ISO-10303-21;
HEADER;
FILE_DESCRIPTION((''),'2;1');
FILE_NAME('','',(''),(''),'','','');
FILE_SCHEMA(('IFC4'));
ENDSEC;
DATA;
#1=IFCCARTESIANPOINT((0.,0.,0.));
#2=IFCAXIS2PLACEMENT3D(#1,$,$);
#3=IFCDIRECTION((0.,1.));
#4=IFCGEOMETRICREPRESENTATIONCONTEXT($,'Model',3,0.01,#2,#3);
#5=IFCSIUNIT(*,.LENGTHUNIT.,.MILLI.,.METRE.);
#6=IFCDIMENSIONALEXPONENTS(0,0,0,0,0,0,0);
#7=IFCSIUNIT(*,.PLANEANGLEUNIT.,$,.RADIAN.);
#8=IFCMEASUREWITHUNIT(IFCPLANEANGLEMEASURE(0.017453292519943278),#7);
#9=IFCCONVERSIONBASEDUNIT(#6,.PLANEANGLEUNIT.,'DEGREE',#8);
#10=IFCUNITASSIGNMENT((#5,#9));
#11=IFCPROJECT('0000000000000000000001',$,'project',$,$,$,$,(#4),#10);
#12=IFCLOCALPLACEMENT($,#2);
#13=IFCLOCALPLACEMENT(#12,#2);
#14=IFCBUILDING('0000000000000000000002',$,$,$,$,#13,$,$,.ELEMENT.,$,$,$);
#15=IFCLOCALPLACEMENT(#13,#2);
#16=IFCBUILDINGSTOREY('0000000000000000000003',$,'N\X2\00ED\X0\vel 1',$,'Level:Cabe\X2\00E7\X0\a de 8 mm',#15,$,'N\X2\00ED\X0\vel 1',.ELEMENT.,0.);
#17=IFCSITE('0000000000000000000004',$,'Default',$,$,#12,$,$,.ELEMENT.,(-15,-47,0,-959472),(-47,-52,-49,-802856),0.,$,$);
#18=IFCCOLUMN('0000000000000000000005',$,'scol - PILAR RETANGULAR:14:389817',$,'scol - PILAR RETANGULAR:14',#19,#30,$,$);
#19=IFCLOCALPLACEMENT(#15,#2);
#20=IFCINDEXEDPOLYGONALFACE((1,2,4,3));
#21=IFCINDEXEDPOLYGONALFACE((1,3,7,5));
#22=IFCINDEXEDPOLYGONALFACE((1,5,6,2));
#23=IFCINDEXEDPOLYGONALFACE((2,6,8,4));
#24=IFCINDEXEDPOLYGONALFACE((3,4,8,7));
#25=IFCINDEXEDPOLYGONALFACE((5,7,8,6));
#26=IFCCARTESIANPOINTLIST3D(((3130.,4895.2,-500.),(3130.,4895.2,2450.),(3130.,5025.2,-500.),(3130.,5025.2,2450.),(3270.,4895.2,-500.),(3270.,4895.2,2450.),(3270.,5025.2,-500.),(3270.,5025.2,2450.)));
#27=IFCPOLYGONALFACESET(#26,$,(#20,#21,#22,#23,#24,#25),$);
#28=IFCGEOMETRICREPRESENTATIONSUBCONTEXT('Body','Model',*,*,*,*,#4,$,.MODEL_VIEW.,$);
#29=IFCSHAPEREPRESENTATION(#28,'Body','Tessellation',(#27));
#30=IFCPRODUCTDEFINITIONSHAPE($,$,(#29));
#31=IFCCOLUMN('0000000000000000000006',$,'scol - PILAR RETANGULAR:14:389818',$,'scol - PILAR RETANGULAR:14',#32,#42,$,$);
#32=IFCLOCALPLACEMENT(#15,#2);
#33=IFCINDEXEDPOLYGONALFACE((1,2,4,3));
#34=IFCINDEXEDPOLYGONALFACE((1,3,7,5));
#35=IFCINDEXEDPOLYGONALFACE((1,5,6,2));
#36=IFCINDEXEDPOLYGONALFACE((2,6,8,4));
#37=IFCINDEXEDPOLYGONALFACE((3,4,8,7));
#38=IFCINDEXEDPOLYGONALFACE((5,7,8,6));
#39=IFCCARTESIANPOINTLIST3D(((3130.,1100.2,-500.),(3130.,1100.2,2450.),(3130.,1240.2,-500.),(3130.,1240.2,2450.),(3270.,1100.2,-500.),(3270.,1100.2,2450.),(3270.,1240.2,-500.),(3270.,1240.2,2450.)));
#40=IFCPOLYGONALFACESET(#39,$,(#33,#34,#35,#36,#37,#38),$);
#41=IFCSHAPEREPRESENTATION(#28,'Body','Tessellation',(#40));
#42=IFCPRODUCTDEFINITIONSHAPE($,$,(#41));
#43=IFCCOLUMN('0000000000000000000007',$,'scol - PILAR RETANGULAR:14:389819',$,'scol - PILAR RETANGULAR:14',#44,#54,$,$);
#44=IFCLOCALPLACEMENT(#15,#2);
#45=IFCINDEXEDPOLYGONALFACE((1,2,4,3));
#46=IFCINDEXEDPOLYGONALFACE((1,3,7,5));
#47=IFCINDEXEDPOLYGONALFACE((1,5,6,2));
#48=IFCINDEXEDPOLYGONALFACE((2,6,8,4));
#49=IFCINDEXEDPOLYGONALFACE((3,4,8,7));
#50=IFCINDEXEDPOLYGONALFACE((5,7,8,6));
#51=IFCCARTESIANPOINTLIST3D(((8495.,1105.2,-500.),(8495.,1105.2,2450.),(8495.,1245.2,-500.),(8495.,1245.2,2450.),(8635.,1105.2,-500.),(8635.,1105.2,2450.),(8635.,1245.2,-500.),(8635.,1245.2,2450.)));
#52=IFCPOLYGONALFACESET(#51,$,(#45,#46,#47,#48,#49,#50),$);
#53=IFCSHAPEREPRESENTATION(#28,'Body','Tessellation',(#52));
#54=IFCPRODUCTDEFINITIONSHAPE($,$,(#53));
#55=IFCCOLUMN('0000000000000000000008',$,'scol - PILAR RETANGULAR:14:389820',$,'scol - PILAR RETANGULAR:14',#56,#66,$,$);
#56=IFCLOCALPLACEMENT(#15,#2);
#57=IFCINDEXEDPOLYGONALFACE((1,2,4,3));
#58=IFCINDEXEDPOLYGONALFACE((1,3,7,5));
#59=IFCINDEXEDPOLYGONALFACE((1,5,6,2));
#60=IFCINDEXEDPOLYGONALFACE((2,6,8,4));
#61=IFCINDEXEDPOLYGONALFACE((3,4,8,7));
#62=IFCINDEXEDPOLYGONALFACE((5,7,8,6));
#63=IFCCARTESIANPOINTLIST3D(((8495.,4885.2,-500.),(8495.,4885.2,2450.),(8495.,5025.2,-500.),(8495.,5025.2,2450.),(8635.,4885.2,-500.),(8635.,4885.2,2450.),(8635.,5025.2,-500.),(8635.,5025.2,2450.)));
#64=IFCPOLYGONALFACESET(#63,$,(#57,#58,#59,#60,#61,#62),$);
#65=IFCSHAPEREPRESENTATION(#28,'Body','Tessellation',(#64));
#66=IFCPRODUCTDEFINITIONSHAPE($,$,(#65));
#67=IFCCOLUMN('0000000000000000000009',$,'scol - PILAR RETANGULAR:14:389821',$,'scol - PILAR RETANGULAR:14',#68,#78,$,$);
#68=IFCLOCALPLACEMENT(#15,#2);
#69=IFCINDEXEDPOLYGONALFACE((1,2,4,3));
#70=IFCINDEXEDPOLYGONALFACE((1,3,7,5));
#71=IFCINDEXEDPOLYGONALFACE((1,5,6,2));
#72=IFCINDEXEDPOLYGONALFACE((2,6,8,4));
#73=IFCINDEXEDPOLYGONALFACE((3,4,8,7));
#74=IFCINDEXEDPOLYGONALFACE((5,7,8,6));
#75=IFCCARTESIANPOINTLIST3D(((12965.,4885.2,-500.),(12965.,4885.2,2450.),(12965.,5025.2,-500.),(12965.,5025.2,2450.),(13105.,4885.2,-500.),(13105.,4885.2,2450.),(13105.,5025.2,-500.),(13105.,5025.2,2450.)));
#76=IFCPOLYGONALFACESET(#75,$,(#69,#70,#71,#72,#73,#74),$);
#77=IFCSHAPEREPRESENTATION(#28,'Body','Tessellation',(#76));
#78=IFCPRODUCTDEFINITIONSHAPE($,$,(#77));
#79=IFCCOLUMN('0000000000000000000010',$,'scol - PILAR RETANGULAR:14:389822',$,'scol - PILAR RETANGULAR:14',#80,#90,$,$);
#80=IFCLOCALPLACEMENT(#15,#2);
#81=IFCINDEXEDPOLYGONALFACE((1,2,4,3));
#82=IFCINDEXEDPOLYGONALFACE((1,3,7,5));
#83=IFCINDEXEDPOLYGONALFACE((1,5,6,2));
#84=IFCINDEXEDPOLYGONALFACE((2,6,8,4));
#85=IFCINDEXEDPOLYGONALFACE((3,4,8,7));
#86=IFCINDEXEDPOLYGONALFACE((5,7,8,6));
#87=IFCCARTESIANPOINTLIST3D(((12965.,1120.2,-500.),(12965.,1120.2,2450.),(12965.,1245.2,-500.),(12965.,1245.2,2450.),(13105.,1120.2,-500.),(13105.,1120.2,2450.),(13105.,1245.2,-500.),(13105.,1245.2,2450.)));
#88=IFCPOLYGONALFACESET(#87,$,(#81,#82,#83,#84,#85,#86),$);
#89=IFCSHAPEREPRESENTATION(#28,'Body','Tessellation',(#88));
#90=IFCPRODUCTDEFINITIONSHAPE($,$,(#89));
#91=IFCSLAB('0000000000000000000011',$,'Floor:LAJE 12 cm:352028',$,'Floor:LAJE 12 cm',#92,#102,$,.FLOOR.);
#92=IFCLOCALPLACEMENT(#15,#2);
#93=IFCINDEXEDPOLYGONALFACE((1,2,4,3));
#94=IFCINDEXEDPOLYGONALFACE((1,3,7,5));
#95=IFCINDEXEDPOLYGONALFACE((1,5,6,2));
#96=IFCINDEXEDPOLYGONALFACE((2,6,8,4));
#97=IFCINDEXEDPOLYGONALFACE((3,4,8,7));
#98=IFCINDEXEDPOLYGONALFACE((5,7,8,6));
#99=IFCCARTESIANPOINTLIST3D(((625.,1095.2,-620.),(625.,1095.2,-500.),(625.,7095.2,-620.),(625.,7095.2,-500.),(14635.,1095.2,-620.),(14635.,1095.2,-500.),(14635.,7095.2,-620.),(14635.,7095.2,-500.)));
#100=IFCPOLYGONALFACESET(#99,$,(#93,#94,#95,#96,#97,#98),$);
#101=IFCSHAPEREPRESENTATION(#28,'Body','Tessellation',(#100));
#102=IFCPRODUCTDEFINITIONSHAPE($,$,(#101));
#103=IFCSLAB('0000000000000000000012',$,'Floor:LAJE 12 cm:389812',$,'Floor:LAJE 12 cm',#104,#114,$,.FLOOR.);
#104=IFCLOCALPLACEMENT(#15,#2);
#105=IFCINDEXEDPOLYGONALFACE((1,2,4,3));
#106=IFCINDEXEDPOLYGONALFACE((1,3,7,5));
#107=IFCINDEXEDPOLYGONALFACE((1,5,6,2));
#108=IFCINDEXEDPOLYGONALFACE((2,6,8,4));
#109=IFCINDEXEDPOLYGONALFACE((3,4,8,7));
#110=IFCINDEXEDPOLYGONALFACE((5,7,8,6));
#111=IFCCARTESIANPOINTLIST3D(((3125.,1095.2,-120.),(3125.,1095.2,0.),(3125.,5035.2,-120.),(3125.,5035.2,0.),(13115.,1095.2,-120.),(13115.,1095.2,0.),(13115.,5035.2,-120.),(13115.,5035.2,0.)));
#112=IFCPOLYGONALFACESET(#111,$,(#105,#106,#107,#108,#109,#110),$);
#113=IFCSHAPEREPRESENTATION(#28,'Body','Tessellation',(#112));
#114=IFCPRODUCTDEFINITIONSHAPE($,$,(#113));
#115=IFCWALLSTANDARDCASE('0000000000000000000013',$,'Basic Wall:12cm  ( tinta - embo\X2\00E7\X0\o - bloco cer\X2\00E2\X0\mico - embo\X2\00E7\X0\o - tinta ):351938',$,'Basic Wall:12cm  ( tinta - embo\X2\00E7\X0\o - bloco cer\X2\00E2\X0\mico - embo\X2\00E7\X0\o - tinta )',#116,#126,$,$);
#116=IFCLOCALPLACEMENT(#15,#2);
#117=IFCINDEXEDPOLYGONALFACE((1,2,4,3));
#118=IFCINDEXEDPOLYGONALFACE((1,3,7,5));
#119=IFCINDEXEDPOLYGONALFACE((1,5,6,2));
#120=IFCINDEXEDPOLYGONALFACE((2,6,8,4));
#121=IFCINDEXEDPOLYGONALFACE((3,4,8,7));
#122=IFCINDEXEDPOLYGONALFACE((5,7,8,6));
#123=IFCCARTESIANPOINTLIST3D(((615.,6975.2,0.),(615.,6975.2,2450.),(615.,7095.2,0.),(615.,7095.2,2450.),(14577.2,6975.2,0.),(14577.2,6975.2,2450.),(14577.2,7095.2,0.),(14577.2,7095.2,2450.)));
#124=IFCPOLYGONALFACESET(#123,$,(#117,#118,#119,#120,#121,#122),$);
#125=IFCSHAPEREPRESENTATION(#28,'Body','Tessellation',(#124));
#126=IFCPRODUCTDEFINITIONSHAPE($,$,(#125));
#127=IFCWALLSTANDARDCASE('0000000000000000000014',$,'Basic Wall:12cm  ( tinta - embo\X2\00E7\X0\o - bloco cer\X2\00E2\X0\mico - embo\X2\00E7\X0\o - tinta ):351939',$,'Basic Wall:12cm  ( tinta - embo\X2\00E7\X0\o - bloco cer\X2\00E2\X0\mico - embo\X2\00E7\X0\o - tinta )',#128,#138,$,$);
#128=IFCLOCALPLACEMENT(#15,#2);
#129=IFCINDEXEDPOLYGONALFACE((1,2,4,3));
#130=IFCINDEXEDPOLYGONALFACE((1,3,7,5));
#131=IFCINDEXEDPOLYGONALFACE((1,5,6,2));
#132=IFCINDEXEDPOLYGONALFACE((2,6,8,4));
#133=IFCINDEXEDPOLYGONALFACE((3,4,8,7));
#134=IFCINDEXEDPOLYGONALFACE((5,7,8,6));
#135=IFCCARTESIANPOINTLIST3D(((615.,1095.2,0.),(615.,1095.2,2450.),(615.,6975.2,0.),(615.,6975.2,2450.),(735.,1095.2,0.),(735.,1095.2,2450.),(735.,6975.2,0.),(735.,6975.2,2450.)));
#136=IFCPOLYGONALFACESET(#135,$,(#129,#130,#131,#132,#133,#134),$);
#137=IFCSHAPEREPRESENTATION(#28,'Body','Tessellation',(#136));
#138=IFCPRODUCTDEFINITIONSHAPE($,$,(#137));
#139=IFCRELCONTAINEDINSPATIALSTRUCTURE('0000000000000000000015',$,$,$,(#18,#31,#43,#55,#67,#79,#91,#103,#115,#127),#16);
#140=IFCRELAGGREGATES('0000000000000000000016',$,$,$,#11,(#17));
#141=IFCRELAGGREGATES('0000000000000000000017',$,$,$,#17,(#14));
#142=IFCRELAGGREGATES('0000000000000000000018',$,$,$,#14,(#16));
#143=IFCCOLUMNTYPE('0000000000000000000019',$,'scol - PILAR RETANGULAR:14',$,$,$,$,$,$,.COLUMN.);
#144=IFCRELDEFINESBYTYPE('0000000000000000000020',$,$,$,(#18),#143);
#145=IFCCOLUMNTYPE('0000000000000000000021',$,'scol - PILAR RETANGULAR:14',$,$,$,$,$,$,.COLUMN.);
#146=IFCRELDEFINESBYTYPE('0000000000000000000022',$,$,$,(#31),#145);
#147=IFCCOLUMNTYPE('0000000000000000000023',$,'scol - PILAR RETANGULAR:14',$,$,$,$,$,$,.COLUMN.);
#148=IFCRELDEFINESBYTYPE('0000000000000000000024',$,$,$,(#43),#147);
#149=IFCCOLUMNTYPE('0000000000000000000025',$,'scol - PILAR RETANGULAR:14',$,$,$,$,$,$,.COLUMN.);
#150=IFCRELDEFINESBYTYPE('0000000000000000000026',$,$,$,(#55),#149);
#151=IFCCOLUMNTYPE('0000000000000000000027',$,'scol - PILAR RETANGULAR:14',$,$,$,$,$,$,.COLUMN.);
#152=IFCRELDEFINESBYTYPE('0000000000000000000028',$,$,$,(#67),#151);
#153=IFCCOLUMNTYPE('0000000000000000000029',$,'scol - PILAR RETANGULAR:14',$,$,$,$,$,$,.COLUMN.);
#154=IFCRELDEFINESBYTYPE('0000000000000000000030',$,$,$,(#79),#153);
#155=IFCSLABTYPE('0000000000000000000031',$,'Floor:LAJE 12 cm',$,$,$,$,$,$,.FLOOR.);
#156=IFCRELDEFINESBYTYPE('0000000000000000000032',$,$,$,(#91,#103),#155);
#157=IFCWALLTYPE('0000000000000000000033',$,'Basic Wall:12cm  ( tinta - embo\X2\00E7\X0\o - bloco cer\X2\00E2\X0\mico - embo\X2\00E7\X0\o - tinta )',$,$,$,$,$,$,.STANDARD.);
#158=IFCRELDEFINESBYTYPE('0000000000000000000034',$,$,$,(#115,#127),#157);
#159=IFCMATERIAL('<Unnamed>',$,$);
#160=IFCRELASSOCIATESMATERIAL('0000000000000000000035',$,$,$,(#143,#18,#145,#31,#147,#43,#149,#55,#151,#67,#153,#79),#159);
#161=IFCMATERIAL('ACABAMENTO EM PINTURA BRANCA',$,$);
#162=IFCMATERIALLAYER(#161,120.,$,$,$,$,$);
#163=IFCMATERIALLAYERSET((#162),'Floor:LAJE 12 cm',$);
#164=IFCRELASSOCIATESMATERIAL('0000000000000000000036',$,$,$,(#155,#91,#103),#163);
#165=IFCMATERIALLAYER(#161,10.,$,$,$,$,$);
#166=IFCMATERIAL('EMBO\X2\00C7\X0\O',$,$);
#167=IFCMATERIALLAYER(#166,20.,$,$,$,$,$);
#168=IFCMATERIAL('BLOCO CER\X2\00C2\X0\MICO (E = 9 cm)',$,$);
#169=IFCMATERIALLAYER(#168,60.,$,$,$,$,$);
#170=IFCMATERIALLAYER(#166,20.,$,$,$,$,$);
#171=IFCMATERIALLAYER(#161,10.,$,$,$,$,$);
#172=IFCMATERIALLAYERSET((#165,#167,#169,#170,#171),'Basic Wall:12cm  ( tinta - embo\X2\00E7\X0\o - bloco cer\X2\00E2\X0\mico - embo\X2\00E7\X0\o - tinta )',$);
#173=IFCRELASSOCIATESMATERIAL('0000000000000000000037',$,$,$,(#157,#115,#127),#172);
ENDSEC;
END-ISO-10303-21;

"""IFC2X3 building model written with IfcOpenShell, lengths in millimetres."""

from ifc_helpers import new_model, entity, si_unit, converted_unit, direction, frame, frame_2d, origin, origin_2d_with_axis, place, context, subcontext, project, spatial, rectangle, extrude, source, transform, mapped, material, layer, layer_set, layer_usage, type_object, type_shapes, element, save


model = new_model("IFC2X3")

# Units and contexts
model_context = context("Model", 3, precision=0.01, world=origin(), true_north=direction((0.0, 1.0)))
body_context = subcontext(model_context, "Body", "Model", "MODEL_VIEW")
ifc_project = project(units=[si_unit("LENGTHUNIT", "METRE", prefix="MILLI"), converted_unit("PLANEANGLEUNIT", "DEGREE", entity("IfcPlaneAngleMeasure", 0.017453292519943278), si_unit("PLANEANGLEUNIT", "RADIAN"), dimensions=[0, 0, 0, 0, 0, 0, 0])], contexts=[model_context])

# Site, building, storey
site_placement = place(None, origin())
site = spatial("IfcSite", under=ifc_project, at=site_placement, Name="Default", CompositionType="ELEMENT", RefLatitude=(-15, -47, 0, -959472), RefLongitude=(-47, -52, -49, -802856), RefElevation=0.0)
building_placement = place(site_placement, origin())
building = spatial("IfcBuilding", under=site, at=building_placement, CompositionType="ELEMENT")
storey_placement = place(building_placement, origin())
storey = spatial("IfcBuildingStorey", under=building, at=storey_placement, Name="Nível 1", ObjectType="Level:Cabeça de 8 mm", LongName="Nível 1", CompositionType="ELEMENT", Elevation=0.0)

# Columns
ifc_material_1 = material(Name="<Unnamed>")
column_type_1 = type_object("IfcColumnType", Name="scol - PILAR RETANGULAR:14", PredefinedType="COLUMN", material=ifc_material_1)
shared_shape_1 = source(origin(), body_context, "Body", "SweptSolid", [
    extrude(rectangle(XDim=140.0, YDim=130.0, at=frame_2d((0.0, 0.0), x_axis=(1.0, 0.0))), frame((3200.0, 4960.2, -500.0), z_axis=(0.0, 0.0, 1.0), x_axis=(-1.0, 0.0, 0.0)), (0.0, 0.0, 1.0), 2950.0),
])
type_shapes(column_type_1, [shared_shape_1])
column_1_placement = place(storey_placement, origin())
element("IfcColumn", 1, at=column_1_placement, inside=storey, type_object=column_type_1, material=ifc_material_1, Name="scol - PILAR RETANGULAR:14:389817", ObjectType="scol - PILAR RETANGULAR:14", context=body_context, shape_type="MappedRepresentation", body=[
    mapped(shared_shape_1, transform((0.0, 0.0, 0.0), scale=1.0)),
])
column_type_2 = type_object("IfcColumnType", Name="scol - PILAR RETANGULAR:14", PredefinedType="COLUMN", material=ifc_material_1)
shared_shape_2 = source(origin(), body_context, "Body", "SweptSolid", [
    extrude(rectangle(XDim=140.0, YDim=140.0, at=frame_2d((0.0, 0.0), x_axis=(1.0, 0.0))), frame((3200.0, 1170.2, -500.0), z_axis=(0.0, 0.0, 1.0), x_axis=(-1.0, 0.0, 0.0)), (0.0, 0.0, 1.0), 2950.0),
])
type_shapes(column_type_2, [shared_shape_2])
column_2_placement = place(storey_placement, origin())
element("IfcColumn", 2, at=column_2_placement, inside=storey, type_object=column_type_2, material=ifc_material_1, Name="scol - PILAR RETANGULAR:14:389818", ObjectType="scol - PILAR RETANGULAR:14", context=body_context, shape_type="MappedRepresentation", body=[
    mapped(shared_shape_2, transform((0.0, 0.0, 0.0), scale=1.0)),
])
column_type_3 = type_object("IfcColumnType", Name="scol - PILAR RETANGULAR:14", PredefinedType="COLUMN", material=ifc_material_1)
shared_shape_3 = source(origin(), body_context, "Body", "SweptSolid", [
    extrude(rectangle(XDim=140.0, YDim=140.0, at=frame_2d((0.0, 0.0), x_axis=(1.0, 0.0))), frame((8565.0, 1175.2, -500.0), z_axis=(0.0, 0.0, 1.0), x_axis=(-1.0, 0.0, 0.0)), (0.0, 0.0, 1.0), 2950.0),
])
type_shapes(column_type_3, [shared_shape_3])
column_3_placement = place(storey_placement, origin())
element("IfcColumn", 3, at=column_3_placement, inside=storey, type_object=column_type_3, material=ifc_material_1, Name="scol - PILAR RETANGULAR:14:389819", ObjectType="scol - PILAR RETANGULAR:14", context=body_context, shape_type="MappedRepresentation", body=[
    mapped(shared_shape_3, transform((0.0, 0.0, 0.0), scale=1.0)),
])
column_type_4 = type_object("IfcColumnType", Name="scol - PILAR RETANGULAR:14", PredefinedType="COLUMN", material=ifc_material_1)
shared_shape_4 = source(origin(), body_context, "Body", "SweptSolid", [
    extrude(rectangle(XDim=140.0, YDim=140.0, at=frame_2d((0.0, 0.0), x_axis=(1.0, 0.0))), frame((8565.0, 4955.2, -500.0), z_axis=(0.0, 0.0, 1.0), x_axis=(-1.0, 0.0, 0.0)), (0.0, 0.0, 1.0), 2950.0),
])
type_shapes(column_type_4, [shared_shape_4])
column_4_placement = place(storey_placement, origin())
element("IfcColumn", 4, at=column_4_placement, inside=storey, type_object=column_type_4, material=ifc_material_1, Name="scol - PILAR RETANGULAR:14:389820", ObjectType="scol - PILAR RETANGULAR:14", context=body_context, shape_type="MappedRepresentation", body=[
    mapped(shared_shape_4, transform((0.0, 0.0, 0.0), scale=1.0)),
])
column_type_5 = type_object("IfcColumnType", Name="scol - PILAR RETANGULAR:14", PredefinedType="COLUMN", material=ifc_material_1)
shared_shape_5 = source(origin(), body_context, "Body", "SweptSolid", [
    extrude(rectangle(XDim=140.0, YDim=140.0, at=frame_2d((0.0, 0.0), x_axis=(1.0, 0.0))), frame((13035.0, 4955.2, -500.0), z_axis=(0.0, 0.0, 1.0), x_axis=(-1.0, 0.0, 0.0)), (0.0, 0.0, 1.0), 2950.0),
])
type_shapes(column_type_5, [shared_shape_5])
column_5_placement = place(storey_placement, origin())
element("IfcColumn", 5, at=column_5_placement, inside=storey, type_object=column_type_5, material=ifc_material_1, Name="scol - PILAR RETANGULAR:14:389821", ObjectType="scol - PILAR RETANGULAR:14", context=body_context, shape_type="MappedRepresentation", body=[
    mapped(shared_shape_5, transform((0.0, 0.0, 0.0), scale=1.0)),
])
column_type_6 = type_object("IfcColumnType", Name="scol - PILAR RETANGULAR:14", PredefinedType="COLUMN", material=ifc_material_1)
shared_shape_6 = source(origin(), body_context, "Body", "SweptSolid", [
    extrude(rectangle(XDim=140.0, YDim=125.0, at=frame_2d((0.0, 0.0), x_axis=(1.0, 0.0))), frame((13035.0, 1182.7, -500.0), z_axis=(0.0, 0.0, 1.0), x_axis=(-1.0, 0.0, 0.0)), (0.0, 0.0, 1.0), 2950.0),
])
type_shapes(column_type_6, [shared_shape_6])
column_6_placement = place(storey_placement, origin())
element("IfcColumn", 6, at=column_6_placement, inside=storey, type_object=column_type_6, material=ifc_material_1, Name="scol - PILAR RETANGULAR:14:389822", ObjectType="scol - PILAR RETANGULAR:14", context=body_context, shape_type="MappedRepresentation", body=[
    mapped(shared_shape_6, transform((0.0, 0.0, 0.0), scale=1.0)),
])

# Slabs
ifc_material_2 = material(Name="ACABAMENTO EM PINTURA BRANCA")
ifc_layer_1 = layer(ifc_material_2, 120.0)
ifc_layer_set_1 = layer_set([ifc_layer_1], Name="Floor:LAJE 12 cm")
ifc_layer_usage_1 = layer_usage(ifc_layer_set_1, "AXIS3", "POSITIVE", 0.0)
slab_type = type_object("IfcSlabType", Name="Floor:LAJE 12 cm", PredefinedType="FLOOR", material=ifc_layer_set_1)
slab_1_placement = place(storey_placement, origin())
element("IfcSlab", 7, at=slab_1_placement, inside=storey, type_object=slab_type, material=ifc_layer_usage_1, Name="Floor:LAJE 12 cm:352028", ObjectType="Floor:LAJE 12 cm", PredefinedType="FLOOR", context=body_context, shape_type="SweptSolid", body=[
    extrude(rectangle(XDim=6000.0, YDim=14010.0, at=frame_2d((0.0, 0.0), x_axis=(1.0, 0.0))), frame((7630.0, 4095.2, -500.0), z_axis=(0.0, 0.0, -1.0), x_axis=(0.0, 1.0, 0.0)), (0.0, 0.0, 1.0), 120.0),
])
ifc_layer_usage_2 = layer_usage(ifc_layer_set_1, "AXIS3", "POSITIVE", 0.0)
slab_2_placement = place(storey_placement, origin())
element("IfcSlab", 8, at=slab_2_placement, inside=storey, type_object=slab_type, material=ifc_layer_usage_2, Name="Floor:LAJE 12 cm:389812", ObjectType="Floor:LAJE 12 cm", PredefinedType="FLOOR", context=body_context, shape_type="SweptSolid", body=[
    extrude(rectangle(XDim=3940.0, YDim=9990.0, at=origin_2d_with_axis()), frame((8120.0, 3065.2, 0.0), z_axis=(0.0, 0.0, -1.0), x_axis=(0.0, 1.0, 0.0)), (0.0, 0.0, 1.0), 120.0),
])

# Walls
ifc_layer_2 = layer(ifc_material_2, 10.0)
ifc_material_3 = material(Name="EMBOÇO")
ifc_layer_3 = layer(ifc_material_3, 20.0)
ifc_material_4 = material(Name="BLOCO CERÂMICO (E = 9 cm)")
ifc_layer_4 = layer(ifc_material_4, 60.0)
ifc_layer_5 = layer(ifc_material_3, 20.0)
ifc_layer_6 = layer(ifc_material_2, 10.0)
ifc_layer_set_2 = layer_set([ifc_layer_2, ifc_layer_3, ifc_layer_4, ifc_layer_5, ifc_layer_6], Name="Basic Wall:12cm  ( tinta - emboço - bloco cerâmico - emboço - tinta )")
ifc_layer_usage_3 = layer_usage(ifc_layer_set_2, "AXIS2", "NEGATIVE", 60.0)
wall_type = type_object("IfcWallType", Name="Basic Wall:12cm  ( tinta - emboço - bloco cerâmico - emboço - tinta )", PredefinedType="STANDARD", material=ifc_layer_set_2)
wall_1_placement = place(storey_placement, frame((615.0, 7035.2, 0.0)))
element("IfcWallStandardCase", 9, at=wall_1_placement, inside=storey, type_object=wall_type, material=ifc_layer_usage_3, Name="Basic Wall:12cm  ( tinta - emboço - bloco cerâmico - emboço - tinta ):351938", ObjectType="Basic Wall:12cm  ( tinta - emboço - bloco cerâmico - emboço - tinta )", context=body_context, shape_type="SweptSolid", body=[
    extrude(rectangle(XDim=13962.2, YDim=120.0, at=frame_2d((6981.1, 0.0), x_axis=(-1.0, 0.0))), origin(), (0.0, 0.0, 1.0), 2450.0),
])
ifc_layer_usage_4 = layer_usage(ifc_layer_set_2, "AXIS2", "NEGATIVE", 60.0)
wall_2_placement = place(storey_placement, frame((675.0, 6975.2, 0.0), z_axis=(0.0, 0.0, 1.0), x_axis=(0.0, -1.0, 0.0)))
element("IfcWallStandardCase", 10, at=wall_2_placement, inside=storey, type_object=wall_type, material=ifc_layer_usage_4, Name="Basic Wall:12cm  ( tinta - emboço - bloco cerâmico - emboço - tinta ):351939", ObjectType="Basic Wall:12cm  ( tinta - emboço - bloco cerâmico - emboço - tinta )", context=body_context, shape_type="SweptSolid", body=[
    extrude(rectangle(XDim=5880.0, YDim=120.0, at=frame_2d((2940.0, 0.0), x_axis=(-1.0, 0.0))), origin(), (0.0, 0.0, 1.0), 2450.0),
])

save(model, "model.ifc")
